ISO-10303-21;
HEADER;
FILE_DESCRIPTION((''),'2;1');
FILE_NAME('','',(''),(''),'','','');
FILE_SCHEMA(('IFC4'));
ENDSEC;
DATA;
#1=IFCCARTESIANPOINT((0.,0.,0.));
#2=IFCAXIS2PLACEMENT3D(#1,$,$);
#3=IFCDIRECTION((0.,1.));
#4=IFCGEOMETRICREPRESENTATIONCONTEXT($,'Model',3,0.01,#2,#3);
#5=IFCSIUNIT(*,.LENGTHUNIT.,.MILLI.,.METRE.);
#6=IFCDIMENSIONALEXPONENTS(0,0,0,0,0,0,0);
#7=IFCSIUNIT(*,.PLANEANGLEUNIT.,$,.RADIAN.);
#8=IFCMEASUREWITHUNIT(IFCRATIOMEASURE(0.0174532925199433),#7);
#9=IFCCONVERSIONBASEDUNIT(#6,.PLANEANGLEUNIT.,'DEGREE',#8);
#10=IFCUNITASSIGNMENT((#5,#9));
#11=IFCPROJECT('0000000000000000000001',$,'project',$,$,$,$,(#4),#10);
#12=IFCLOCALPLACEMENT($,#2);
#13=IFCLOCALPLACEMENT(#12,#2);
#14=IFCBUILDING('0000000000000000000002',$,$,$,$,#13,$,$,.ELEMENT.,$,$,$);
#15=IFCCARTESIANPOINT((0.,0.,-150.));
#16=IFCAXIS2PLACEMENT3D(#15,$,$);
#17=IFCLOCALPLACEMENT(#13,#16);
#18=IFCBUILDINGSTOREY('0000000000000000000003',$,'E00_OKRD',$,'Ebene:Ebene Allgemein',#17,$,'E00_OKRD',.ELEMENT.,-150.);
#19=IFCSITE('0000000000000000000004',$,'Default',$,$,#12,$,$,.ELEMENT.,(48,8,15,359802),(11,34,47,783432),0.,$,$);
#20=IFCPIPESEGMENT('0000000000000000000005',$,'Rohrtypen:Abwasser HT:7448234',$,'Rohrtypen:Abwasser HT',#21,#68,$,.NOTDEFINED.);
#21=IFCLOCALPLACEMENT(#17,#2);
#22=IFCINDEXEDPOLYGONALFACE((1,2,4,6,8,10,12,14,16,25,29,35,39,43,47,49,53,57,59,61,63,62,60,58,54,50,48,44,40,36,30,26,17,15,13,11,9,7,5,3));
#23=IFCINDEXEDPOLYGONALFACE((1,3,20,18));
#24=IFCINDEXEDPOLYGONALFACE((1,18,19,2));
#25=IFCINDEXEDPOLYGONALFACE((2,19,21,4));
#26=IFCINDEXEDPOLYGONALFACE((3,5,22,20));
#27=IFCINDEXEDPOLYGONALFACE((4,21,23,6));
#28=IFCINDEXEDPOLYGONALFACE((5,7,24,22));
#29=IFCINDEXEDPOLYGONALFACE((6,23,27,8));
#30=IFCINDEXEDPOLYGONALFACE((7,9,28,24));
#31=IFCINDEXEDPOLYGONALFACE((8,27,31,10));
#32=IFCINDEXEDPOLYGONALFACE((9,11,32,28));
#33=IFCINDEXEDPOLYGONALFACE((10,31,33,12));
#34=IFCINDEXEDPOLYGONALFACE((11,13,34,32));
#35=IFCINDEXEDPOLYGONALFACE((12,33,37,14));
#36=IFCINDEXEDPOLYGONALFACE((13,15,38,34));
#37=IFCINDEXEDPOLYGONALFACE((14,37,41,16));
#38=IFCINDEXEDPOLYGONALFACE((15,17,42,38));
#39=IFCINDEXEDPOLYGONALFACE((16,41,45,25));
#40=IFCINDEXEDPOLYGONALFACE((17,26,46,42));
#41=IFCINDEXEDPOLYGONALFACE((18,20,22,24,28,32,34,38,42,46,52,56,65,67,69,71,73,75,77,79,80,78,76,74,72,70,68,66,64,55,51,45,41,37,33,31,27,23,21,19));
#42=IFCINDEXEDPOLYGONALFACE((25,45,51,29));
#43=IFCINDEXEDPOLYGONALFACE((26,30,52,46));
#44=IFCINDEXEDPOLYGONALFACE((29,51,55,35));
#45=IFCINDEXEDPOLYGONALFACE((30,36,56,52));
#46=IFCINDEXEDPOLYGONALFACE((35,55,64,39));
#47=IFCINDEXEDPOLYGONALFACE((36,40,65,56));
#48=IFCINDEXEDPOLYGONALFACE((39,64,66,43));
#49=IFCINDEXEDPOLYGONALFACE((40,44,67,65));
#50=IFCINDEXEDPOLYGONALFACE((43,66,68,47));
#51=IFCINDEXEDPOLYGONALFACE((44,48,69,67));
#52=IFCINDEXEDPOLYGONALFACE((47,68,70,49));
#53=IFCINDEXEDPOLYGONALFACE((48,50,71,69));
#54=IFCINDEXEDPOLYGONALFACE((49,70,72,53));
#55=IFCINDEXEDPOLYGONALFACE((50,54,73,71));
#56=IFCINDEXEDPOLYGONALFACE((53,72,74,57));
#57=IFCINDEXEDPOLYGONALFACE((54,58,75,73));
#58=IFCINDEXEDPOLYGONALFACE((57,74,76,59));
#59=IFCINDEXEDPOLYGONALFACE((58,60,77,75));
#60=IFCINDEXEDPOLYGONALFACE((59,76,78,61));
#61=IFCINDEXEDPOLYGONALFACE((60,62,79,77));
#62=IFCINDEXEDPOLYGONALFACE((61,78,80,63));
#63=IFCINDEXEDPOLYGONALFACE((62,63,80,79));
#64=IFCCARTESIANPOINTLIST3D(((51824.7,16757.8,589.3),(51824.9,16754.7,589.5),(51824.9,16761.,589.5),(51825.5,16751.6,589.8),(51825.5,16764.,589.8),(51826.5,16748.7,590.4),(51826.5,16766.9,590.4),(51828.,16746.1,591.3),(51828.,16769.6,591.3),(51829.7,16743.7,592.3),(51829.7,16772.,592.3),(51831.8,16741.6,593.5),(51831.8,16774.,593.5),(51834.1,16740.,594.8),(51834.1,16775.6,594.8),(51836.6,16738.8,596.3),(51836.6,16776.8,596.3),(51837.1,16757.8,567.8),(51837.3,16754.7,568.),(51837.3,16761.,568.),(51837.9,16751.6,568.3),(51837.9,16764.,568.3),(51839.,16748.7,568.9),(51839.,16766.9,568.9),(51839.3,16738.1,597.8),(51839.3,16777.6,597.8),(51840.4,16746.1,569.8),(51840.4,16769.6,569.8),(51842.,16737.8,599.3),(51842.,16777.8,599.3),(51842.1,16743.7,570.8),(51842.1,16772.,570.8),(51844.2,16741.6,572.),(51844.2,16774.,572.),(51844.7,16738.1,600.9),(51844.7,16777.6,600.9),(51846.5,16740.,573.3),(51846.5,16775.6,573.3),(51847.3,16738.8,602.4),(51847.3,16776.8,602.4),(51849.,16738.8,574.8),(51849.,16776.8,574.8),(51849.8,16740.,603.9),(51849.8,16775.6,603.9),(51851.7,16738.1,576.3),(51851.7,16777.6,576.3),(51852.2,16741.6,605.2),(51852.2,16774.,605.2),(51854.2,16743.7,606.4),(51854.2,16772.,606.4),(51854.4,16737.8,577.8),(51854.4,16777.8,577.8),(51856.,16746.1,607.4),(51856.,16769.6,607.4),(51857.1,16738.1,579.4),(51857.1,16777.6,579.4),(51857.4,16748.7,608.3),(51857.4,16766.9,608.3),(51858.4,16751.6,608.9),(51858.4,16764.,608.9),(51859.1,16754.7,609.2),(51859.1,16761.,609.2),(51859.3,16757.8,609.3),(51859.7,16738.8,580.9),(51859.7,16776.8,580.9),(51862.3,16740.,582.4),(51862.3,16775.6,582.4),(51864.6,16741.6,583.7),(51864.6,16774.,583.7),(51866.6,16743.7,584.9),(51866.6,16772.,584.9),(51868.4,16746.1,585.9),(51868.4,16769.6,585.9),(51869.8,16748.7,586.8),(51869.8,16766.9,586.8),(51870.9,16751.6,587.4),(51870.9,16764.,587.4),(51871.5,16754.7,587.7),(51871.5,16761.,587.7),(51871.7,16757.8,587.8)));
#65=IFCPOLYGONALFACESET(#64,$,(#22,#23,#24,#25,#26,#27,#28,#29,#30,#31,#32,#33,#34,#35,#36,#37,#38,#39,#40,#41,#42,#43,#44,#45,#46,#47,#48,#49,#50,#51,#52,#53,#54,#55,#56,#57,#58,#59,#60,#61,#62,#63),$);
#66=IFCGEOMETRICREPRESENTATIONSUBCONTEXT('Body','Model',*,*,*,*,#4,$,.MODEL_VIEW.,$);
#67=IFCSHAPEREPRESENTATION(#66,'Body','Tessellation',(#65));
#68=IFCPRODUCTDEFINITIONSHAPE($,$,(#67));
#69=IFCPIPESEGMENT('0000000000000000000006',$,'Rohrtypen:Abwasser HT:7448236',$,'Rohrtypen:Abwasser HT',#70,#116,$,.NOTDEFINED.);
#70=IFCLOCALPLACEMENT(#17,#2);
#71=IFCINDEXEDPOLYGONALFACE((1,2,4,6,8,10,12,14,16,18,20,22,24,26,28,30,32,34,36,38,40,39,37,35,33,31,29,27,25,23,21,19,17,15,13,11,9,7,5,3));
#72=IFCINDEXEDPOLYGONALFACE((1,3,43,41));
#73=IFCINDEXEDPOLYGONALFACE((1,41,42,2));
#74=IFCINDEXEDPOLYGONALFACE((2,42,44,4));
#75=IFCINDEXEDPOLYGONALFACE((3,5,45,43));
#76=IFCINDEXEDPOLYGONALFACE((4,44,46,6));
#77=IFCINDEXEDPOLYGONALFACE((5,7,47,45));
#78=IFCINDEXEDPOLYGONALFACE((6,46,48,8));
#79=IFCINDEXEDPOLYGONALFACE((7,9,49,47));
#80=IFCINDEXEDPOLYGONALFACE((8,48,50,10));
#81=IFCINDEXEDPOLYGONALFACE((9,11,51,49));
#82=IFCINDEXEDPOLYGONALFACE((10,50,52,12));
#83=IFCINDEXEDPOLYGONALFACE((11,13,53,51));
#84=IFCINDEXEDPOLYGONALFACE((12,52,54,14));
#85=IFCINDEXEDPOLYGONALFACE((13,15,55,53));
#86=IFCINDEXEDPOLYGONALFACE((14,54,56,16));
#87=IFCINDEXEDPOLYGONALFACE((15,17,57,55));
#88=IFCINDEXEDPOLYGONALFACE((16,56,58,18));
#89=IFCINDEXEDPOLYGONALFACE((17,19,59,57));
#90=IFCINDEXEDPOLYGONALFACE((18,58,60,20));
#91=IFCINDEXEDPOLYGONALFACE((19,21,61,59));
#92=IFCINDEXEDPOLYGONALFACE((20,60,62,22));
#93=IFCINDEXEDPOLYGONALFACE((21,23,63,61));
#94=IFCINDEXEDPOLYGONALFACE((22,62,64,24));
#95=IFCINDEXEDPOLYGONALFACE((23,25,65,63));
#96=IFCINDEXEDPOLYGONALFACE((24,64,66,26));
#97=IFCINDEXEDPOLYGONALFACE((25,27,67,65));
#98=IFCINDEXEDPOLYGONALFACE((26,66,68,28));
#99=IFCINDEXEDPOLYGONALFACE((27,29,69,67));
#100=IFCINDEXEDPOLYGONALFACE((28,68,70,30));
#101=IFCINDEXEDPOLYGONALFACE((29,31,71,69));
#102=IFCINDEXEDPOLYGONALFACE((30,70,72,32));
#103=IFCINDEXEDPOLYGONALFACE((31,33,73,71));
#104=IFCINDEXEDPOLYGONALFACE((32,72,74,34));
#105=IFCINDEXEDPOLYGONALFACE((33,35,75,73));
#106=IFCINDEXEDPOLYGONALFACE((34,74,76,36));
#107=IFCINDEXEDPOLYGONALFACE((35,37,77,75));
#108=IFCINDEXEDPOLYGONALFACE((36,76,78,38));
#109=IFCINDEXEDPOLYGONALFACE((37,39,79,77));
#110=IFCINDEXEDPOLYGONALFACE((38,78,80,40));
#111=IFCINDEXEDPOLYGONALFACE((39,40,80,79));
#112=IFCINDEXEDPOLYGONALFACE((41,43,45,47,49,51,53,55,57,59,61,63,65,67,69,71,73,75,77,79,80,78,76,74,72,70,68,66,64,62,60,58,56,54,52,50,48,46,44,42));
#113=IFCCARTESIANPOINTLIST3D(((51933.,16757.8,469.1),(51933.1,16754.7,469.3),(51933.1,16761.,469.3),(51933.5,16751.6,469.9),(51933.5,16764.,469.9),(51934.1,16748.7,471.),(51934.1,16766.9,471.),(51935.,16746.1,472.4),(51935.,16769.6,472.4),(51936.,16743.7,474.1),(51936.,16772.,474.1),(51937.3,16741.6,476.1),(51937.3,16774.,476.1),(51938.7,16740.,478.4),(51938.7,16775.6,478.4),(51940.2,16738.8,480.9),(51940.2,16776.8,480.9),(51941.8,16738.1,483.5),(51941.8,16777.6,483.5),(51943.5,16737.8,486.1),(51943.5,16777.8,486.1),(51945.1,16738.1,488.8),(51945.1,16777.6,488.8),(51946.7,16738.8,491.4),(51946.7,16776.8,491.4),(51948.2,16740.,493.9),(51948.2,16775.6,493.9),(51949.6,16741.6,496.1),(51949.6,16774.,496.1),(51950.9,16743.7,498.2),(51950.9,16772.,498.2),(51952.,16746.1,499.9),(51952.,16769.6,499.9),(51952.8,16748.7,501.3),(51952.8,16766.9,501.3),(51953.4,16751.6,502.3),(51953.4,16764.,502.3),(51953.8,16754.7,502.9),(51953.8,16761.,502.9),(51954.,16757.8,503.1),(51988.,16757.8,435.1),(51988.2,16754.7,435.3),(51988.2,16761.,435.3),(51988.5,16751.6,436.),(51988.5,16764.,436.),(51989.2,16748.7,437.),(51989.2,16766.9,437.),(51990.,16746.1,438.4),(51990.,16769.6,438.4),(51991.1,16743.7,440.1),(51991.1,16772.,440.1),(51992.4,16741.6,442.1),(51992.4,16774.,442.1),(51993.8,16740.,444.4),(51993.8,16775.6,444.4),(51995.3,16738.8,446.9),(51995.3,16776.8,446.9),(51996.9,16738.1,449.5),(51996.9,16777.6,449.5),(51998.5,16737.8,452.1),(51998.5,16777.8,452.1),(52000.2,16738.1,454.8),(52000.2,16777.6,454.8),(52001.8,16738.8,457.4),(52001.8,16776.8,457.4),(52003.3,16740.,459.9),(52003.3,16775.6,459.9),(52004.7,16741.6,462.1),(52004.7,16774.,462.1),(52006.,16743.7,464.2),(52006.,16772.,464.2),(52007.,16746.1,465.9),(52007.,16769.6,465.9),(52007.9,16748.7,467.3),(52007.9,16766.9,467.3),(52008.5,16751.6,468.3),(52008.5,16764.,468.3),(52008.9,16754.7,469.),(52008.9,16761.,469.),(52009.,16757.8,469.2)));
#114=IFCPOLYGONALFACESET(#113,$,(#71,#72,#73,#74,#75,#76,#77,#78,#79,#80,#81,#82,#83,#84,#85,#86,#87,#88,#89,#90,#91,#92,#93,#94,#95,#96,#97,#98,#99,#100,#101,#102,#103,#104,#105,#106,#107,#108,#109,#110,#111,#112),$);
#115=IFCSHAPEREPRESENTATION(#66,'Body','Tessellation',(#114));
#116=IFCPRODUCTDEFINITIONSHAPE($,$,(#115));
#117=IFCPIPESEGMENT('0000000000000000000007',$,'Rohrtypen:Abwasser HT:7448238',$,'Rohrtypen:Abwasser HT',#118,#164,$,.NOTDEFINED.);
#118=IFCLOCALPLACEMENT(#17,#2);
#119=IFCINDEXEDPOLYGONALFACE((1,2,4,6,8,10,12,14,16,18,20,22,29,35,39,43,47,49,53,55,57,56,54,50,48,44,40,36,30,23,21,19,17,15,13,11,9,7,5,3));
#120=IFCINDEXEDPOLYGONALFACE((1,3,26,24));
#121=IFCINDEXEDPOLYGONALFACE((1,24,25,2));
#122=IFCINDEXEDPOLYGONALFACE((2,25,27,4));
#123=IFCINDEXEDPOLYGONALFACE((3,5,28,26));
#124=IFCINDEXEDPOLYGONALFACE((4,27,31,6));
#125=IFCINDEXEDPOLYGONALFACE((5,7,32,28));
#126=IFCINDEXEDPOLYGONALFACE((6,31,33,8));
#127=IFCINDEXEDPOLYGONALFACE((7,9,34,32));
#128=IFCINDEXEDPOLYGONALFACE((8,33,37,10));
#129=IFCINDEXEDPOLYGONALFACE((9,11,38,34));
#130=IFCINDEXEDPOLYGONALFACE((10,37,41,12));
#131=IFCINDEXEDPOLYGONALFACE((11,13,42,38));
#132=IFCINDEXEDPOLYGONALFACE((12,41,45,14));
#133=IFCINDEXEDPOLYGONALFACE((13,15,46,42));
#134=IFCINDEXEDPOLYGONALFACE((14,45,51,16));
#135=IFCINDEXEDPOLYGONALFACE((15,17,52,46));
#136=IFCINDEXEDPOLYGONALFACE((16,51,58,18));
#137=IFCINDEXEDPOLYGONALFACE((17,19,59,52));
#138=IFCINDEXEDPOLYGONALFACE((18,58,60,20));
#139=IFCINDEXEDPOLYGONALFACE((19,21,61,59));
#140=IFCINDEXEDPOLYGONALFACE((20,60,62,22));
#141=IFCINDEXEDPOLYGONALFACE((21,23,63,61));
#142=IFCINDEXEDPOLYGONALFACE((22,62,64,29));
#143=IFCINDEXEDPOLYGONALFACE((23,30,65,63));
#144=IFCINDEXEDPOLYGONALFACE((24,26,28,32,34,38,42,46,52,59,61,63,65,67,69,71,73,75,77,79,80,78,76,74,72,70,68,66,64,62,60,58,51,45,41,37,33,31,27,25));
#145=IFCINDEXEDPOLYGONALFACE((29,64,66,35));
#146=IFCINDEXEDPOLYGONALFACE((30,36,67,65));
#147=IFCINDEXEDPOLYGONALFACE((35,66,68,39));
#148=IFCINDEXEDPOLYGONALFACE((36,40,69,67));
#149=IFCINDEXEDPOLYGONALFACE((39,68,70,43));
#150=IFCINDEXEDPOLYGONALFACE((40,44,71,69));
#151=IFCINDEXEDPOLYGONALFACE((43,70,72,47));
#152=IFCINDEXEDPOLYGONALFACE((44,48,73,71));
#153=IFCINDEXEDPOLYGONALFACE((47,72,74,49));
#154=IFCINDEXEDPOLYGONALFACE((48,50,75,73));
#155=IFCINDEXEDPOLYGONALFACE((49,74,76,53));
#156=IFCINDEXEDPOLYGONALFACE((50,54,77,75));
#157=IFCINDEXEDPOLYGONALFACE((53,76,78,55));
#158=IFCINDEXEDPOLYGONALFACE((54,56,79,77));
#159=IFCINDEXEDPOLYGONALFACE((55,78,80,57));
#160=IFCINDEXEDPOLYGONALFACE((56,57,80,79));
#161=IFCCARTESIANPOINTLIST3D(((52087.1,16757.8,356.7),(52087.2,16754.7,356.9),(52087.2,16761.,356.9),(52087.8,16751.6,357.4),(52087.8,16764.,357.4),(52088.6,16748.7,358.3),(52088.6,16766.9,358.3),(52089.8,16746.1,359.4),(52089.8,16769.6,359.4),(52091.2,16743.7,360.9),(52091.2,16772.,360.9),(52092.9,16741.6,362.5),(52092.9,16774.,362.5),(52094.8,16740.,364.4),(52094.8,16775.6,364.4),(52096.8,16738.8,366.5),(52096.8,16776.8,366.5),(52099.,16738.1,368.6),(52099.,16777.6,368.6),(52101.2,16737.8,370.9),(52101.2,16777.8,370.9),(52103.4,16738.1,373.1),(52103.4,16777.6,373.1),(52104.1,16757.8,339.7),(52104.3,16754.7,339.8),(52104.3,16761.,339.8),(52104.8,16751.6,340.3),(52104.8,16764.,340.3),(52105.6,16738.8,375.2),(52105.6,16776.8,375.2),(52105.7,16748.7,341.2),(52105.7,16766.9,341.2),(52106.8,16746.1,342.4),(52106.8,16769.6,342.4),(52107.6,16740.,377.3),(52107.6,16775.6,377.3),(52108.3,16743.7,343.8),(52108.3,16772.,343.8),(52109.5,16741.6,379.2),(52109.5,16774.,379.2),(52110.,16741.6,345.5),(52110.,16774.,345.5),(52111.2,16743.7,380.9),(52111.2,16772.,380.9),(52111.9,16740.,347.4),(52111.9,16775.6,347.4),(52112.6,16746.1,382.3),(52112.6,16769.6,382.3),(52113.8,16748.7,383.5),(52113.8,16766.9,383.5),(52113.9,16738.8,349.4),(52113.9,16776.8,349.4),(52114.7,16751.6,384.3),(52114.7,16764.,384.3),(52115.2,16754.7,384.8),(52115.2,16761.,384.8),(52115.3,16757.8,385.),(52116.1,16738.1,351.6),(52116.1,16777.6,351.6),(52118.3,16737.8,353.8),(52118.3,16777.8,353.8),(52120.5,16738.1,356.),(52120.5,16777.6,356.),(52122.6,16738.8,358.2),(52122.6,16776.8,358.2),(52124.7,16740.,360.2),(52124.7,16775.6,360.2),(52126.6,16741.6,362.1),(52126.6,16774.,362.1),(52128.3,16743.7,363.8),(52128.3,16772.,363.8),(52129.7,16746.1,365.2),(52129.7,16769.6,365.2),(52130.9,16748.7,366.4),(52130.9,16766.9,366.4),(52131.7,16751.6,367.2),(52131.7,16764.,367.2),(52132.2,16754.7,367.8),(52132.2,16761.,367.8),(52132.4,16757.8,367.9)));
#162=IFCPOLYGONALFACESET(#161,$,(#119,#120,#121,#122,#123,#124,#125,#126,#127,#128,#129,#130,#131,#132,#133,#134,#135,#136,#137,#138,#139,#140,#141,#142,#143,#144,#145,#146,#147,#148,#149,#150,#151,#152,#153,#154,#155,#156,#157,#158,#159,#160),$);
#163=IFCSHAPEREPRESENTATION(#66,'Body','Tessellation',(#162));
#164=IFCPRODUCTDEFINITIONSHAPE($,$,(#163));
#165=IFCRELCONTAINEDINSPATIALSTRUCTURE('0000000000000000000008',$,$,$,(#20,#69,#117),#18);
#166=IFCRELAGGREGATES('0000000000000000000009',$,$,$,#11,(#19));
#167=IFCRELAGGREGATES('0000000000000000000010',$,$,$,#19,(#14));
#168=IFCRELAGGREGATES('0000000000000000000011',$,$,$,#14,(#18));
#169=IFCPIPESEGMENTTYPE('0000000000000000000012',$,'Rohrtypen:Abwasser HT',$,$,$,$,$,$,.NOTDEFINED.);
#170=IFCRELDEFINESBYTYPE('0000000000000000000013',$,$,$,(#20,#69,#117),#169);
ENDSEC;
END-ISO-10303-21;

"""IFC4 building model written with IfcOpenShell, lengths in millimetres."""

from ifc_helpers import new_model, entity, si_unit, converted_unit, direction, frame, origin, place, context, subcontext, project, spatial, indexed_curve, outline, extrude, type_object, element, save


model = new_model("IFC4")

# Units and contexts
model_context = context("Model", 3, precision=0.01, world=origin(), true_north=direction((0.0, 1.0)))
body_context = subcontext(model_context, "Body", "Model", "MODEL_VIEW")
ifc_project = project(units=[si_unit("LENGTHUNIT", "METRE", prefix="MILLI"), converted_unit("PLANEANGLEUNIT", "DEGREE", entity("IfcRatioMeasure", 0.0174532925199433), si_unit("PLANEANGLEUNIT", "RADIAN"), dimensions=[0, 0, 0, 0, 0, 0, 0])], contexts=[model_context])

# Site, building, storey
site_placement = place(None, origin())
site = spatial("IfcSite", under=ifc_project, at=site_placement, Name="Default", CompositionType="ELEMENT", RefLatitude=(48, 8, 15, 359802), RefLongitude=(11, 34, 47, 783432), RefElevation=0.0)
building_placement = place(site_placement, origin())
building = spatial("IfcBuilding", under=site, at=building_placement, CompositionType="ELEMENT")
storey_placement = place(building_placement, frame((0.0, 0.0, -150.0)))
storey = spatial("IfcBuildingStorey", under=building, at=storey_placement, Name="E00_OKRD", ObjectType="Ebene:Ebene Allgemein", LongName="E00_OKRD", CompositionType="ELEMENT", Elevation=-150.0)

# Pipe segments
pipe_segment_type_1 = type_object("IfcPipeSegmentType", Name="Rohrtypen:Abwasser HT", PredefinedType="NOTDEFINED")
pipe_segment_1_placement = place(storey_placement, origin())
element("IfcPipeSegment", 1, at=pipe_segment_1_placement, inside=storey, type_object=pipe_segment_type_1, Name="Rohrtypen:Abwasser HT:7448234", ObjectType="Rohrtypen:Abwasser HT", PredefinedType="NOTDEFINED", context=body_context, shape_type="SweptSolid", body=[
    extrude(outline(indexed_curve([(20.0, 0.0), (19.8, 3.1), (19.0, 6.2), (17.8, 9.1), (16.2, 11.8), (14.1, 14.1), (11.8, 16.2), (9.1, 17.8), (6.2, 19.0), (3.1, 19.8), (0.0, 20.0), (-3.1, 19.8), (-6.2, 19.0), (-9.1, 17.8), (-11.8, 16.2), (-14.1, 14.1), (-16.2, 11.8), (-17.8, 9.1), (-19.0, 6.2), (-19.8, 3.1), (-20.0, 0.0), (-19.8, -3.1), (-19.0, -6.2), (-17.8, -9.1), (-16.2, -11.8), (-14.1, -14.1), (-11.8, -16.2), (-9.1, -17.8), (-6.2, -19.0), (-3.1, -19.8), (0.0, -20.0), (3.1, -19.8), (6.2, -19.0), (9.1, -17.8), (11.8, -16.2), (14.1, -14.1), (16.2, -11.8), (17.8, -9.1), (19.0, -6.2), (19.8, -3.1), (20.0, 0.0)], self_intersect=False)), frame((51842.0, 16757.8, 599.3), z_axis=(0.5, 0.0, -0.866025), x_axis=(0.0, -1.0, 0.0)), (0.0, 0.0, 1.0), 24.8),
])
pipe_segment_2_placement = place(storey_placement, origin())
element("IfcPipeSegment", 2, at=pipe_segment_2_placement, inside=storey, type_object=pipe_segment_type_1, Name="Rohrtypen:Abwasser HT:7448236", ObjectType="Rohrtypen:Abwasser HT", PredefinedType="NOTDEFINED", context=body_context, shape_type="SweptSolid", body=[
    extrude(outline(indexed_curve([(20.0, 0.0), (19.8, 3.1), (19.0, 6.2), (17.8, 9.1), (16.2, 11.8), (14.1, 14.1), (11.8, 16.2), (9.1, 17.8), (6.2, 19.0), (3.1, 19.8), (0.0, 20.0), (-3.1, 19.8), (-6.2, 19.0), (-9.1, 17.8), (-11.8, 16.2), (-14.1, 14.1), (-16.2, 11.8), (-17.8, 9.1), (-19.0, 6.2), (-19.8, 3.1), (-20.0, 0.0), (-19.8, -3.1), (-19.0, -6.2), (-17.8, -9.1), (-16.2, -11.8), (-14.1, -14.1), (-11.8, -16.2), (-9.1, -17.8), (-6.2, -19.0), (-3.1, -19.8), (0.0, -20.0), (3.1, -19.8), (6.2, -19.0), (9.1, -17.8), (11.8, -16.2), (14.1, -14.1), (16.2, -11.8), (17.8, -9.1), (19.0, -6.2), (19.8, -3.1), (20.0, 0.0)], self_intersect=False)), frame((51998.5, 16757.8, 452.1), z_axis=(-0.851013, 0.0, 0.525145), x_axis=(0.0, -1.0, 0.0)), (0.0, 0.0, 1.0), 64.7),
])
pipe_segment_3_placement = place(storey_placement, origin())
element("IfcPipeSegment", 3, at=pipe_segment_3_placement, inside=storey, type_object=pipe_segment_type_1, Name="Rohrtypen:Abwasser HT:7448238", ObjectType="Rohrtypen:Abwasser HT", PredefinedType="NOTDEFINED", context=body_context, shape_type="SweptSolid", body=[
    extrude(outline(indexed_curve([(20.0, 0.0), (19.8, 3.1), (19.0, 6.2), (17.8, 9.1), (16.2, 11.8), (14.1, 14.1), (11.8, 16.2), (9.1, 17.8), (6.2, 19.0), (3.1, 19.8), (0.0, 20.0), (-3.1, 19.8), (-6.2, 19.0), (-9.1, 17.8), (-11.8, 16.2), (-14.1, 14.1), (-16.2, 11.8), (-17.8, 9.1), (-19.0, 6.2), (-19.8, 3.1), (-20.0, 0.0), (-19.8, -3.1), (-19.0, -6.2), (-17.8, -9.1), (-16.2, -11.8), (-14.1, -14.1), (-11.8, -16.2), (-9.1, -17.8), (-6.2, -19.0), (-3.1, -19.8), (0.0, -20.0), (3.1, -19.8), (6.2, -19.0), (9.1, -17.8), (11.8, -16.2), (14.1, -14.1), (16.2, -11.8), (17.8, -9.1), (19.0, -6.2), (19.8, -3.1), (20.0, 0.0)], self_intersect=False)), frame((52101.2, 16757.8, 370.9), z_axis=(0.707107, 0.0, -0.707107), x_axis=(0.0, 1.0, 0.0)), (0.0, 0.0, 1.0), 24.1),
])

save(model, "model.ifc")
